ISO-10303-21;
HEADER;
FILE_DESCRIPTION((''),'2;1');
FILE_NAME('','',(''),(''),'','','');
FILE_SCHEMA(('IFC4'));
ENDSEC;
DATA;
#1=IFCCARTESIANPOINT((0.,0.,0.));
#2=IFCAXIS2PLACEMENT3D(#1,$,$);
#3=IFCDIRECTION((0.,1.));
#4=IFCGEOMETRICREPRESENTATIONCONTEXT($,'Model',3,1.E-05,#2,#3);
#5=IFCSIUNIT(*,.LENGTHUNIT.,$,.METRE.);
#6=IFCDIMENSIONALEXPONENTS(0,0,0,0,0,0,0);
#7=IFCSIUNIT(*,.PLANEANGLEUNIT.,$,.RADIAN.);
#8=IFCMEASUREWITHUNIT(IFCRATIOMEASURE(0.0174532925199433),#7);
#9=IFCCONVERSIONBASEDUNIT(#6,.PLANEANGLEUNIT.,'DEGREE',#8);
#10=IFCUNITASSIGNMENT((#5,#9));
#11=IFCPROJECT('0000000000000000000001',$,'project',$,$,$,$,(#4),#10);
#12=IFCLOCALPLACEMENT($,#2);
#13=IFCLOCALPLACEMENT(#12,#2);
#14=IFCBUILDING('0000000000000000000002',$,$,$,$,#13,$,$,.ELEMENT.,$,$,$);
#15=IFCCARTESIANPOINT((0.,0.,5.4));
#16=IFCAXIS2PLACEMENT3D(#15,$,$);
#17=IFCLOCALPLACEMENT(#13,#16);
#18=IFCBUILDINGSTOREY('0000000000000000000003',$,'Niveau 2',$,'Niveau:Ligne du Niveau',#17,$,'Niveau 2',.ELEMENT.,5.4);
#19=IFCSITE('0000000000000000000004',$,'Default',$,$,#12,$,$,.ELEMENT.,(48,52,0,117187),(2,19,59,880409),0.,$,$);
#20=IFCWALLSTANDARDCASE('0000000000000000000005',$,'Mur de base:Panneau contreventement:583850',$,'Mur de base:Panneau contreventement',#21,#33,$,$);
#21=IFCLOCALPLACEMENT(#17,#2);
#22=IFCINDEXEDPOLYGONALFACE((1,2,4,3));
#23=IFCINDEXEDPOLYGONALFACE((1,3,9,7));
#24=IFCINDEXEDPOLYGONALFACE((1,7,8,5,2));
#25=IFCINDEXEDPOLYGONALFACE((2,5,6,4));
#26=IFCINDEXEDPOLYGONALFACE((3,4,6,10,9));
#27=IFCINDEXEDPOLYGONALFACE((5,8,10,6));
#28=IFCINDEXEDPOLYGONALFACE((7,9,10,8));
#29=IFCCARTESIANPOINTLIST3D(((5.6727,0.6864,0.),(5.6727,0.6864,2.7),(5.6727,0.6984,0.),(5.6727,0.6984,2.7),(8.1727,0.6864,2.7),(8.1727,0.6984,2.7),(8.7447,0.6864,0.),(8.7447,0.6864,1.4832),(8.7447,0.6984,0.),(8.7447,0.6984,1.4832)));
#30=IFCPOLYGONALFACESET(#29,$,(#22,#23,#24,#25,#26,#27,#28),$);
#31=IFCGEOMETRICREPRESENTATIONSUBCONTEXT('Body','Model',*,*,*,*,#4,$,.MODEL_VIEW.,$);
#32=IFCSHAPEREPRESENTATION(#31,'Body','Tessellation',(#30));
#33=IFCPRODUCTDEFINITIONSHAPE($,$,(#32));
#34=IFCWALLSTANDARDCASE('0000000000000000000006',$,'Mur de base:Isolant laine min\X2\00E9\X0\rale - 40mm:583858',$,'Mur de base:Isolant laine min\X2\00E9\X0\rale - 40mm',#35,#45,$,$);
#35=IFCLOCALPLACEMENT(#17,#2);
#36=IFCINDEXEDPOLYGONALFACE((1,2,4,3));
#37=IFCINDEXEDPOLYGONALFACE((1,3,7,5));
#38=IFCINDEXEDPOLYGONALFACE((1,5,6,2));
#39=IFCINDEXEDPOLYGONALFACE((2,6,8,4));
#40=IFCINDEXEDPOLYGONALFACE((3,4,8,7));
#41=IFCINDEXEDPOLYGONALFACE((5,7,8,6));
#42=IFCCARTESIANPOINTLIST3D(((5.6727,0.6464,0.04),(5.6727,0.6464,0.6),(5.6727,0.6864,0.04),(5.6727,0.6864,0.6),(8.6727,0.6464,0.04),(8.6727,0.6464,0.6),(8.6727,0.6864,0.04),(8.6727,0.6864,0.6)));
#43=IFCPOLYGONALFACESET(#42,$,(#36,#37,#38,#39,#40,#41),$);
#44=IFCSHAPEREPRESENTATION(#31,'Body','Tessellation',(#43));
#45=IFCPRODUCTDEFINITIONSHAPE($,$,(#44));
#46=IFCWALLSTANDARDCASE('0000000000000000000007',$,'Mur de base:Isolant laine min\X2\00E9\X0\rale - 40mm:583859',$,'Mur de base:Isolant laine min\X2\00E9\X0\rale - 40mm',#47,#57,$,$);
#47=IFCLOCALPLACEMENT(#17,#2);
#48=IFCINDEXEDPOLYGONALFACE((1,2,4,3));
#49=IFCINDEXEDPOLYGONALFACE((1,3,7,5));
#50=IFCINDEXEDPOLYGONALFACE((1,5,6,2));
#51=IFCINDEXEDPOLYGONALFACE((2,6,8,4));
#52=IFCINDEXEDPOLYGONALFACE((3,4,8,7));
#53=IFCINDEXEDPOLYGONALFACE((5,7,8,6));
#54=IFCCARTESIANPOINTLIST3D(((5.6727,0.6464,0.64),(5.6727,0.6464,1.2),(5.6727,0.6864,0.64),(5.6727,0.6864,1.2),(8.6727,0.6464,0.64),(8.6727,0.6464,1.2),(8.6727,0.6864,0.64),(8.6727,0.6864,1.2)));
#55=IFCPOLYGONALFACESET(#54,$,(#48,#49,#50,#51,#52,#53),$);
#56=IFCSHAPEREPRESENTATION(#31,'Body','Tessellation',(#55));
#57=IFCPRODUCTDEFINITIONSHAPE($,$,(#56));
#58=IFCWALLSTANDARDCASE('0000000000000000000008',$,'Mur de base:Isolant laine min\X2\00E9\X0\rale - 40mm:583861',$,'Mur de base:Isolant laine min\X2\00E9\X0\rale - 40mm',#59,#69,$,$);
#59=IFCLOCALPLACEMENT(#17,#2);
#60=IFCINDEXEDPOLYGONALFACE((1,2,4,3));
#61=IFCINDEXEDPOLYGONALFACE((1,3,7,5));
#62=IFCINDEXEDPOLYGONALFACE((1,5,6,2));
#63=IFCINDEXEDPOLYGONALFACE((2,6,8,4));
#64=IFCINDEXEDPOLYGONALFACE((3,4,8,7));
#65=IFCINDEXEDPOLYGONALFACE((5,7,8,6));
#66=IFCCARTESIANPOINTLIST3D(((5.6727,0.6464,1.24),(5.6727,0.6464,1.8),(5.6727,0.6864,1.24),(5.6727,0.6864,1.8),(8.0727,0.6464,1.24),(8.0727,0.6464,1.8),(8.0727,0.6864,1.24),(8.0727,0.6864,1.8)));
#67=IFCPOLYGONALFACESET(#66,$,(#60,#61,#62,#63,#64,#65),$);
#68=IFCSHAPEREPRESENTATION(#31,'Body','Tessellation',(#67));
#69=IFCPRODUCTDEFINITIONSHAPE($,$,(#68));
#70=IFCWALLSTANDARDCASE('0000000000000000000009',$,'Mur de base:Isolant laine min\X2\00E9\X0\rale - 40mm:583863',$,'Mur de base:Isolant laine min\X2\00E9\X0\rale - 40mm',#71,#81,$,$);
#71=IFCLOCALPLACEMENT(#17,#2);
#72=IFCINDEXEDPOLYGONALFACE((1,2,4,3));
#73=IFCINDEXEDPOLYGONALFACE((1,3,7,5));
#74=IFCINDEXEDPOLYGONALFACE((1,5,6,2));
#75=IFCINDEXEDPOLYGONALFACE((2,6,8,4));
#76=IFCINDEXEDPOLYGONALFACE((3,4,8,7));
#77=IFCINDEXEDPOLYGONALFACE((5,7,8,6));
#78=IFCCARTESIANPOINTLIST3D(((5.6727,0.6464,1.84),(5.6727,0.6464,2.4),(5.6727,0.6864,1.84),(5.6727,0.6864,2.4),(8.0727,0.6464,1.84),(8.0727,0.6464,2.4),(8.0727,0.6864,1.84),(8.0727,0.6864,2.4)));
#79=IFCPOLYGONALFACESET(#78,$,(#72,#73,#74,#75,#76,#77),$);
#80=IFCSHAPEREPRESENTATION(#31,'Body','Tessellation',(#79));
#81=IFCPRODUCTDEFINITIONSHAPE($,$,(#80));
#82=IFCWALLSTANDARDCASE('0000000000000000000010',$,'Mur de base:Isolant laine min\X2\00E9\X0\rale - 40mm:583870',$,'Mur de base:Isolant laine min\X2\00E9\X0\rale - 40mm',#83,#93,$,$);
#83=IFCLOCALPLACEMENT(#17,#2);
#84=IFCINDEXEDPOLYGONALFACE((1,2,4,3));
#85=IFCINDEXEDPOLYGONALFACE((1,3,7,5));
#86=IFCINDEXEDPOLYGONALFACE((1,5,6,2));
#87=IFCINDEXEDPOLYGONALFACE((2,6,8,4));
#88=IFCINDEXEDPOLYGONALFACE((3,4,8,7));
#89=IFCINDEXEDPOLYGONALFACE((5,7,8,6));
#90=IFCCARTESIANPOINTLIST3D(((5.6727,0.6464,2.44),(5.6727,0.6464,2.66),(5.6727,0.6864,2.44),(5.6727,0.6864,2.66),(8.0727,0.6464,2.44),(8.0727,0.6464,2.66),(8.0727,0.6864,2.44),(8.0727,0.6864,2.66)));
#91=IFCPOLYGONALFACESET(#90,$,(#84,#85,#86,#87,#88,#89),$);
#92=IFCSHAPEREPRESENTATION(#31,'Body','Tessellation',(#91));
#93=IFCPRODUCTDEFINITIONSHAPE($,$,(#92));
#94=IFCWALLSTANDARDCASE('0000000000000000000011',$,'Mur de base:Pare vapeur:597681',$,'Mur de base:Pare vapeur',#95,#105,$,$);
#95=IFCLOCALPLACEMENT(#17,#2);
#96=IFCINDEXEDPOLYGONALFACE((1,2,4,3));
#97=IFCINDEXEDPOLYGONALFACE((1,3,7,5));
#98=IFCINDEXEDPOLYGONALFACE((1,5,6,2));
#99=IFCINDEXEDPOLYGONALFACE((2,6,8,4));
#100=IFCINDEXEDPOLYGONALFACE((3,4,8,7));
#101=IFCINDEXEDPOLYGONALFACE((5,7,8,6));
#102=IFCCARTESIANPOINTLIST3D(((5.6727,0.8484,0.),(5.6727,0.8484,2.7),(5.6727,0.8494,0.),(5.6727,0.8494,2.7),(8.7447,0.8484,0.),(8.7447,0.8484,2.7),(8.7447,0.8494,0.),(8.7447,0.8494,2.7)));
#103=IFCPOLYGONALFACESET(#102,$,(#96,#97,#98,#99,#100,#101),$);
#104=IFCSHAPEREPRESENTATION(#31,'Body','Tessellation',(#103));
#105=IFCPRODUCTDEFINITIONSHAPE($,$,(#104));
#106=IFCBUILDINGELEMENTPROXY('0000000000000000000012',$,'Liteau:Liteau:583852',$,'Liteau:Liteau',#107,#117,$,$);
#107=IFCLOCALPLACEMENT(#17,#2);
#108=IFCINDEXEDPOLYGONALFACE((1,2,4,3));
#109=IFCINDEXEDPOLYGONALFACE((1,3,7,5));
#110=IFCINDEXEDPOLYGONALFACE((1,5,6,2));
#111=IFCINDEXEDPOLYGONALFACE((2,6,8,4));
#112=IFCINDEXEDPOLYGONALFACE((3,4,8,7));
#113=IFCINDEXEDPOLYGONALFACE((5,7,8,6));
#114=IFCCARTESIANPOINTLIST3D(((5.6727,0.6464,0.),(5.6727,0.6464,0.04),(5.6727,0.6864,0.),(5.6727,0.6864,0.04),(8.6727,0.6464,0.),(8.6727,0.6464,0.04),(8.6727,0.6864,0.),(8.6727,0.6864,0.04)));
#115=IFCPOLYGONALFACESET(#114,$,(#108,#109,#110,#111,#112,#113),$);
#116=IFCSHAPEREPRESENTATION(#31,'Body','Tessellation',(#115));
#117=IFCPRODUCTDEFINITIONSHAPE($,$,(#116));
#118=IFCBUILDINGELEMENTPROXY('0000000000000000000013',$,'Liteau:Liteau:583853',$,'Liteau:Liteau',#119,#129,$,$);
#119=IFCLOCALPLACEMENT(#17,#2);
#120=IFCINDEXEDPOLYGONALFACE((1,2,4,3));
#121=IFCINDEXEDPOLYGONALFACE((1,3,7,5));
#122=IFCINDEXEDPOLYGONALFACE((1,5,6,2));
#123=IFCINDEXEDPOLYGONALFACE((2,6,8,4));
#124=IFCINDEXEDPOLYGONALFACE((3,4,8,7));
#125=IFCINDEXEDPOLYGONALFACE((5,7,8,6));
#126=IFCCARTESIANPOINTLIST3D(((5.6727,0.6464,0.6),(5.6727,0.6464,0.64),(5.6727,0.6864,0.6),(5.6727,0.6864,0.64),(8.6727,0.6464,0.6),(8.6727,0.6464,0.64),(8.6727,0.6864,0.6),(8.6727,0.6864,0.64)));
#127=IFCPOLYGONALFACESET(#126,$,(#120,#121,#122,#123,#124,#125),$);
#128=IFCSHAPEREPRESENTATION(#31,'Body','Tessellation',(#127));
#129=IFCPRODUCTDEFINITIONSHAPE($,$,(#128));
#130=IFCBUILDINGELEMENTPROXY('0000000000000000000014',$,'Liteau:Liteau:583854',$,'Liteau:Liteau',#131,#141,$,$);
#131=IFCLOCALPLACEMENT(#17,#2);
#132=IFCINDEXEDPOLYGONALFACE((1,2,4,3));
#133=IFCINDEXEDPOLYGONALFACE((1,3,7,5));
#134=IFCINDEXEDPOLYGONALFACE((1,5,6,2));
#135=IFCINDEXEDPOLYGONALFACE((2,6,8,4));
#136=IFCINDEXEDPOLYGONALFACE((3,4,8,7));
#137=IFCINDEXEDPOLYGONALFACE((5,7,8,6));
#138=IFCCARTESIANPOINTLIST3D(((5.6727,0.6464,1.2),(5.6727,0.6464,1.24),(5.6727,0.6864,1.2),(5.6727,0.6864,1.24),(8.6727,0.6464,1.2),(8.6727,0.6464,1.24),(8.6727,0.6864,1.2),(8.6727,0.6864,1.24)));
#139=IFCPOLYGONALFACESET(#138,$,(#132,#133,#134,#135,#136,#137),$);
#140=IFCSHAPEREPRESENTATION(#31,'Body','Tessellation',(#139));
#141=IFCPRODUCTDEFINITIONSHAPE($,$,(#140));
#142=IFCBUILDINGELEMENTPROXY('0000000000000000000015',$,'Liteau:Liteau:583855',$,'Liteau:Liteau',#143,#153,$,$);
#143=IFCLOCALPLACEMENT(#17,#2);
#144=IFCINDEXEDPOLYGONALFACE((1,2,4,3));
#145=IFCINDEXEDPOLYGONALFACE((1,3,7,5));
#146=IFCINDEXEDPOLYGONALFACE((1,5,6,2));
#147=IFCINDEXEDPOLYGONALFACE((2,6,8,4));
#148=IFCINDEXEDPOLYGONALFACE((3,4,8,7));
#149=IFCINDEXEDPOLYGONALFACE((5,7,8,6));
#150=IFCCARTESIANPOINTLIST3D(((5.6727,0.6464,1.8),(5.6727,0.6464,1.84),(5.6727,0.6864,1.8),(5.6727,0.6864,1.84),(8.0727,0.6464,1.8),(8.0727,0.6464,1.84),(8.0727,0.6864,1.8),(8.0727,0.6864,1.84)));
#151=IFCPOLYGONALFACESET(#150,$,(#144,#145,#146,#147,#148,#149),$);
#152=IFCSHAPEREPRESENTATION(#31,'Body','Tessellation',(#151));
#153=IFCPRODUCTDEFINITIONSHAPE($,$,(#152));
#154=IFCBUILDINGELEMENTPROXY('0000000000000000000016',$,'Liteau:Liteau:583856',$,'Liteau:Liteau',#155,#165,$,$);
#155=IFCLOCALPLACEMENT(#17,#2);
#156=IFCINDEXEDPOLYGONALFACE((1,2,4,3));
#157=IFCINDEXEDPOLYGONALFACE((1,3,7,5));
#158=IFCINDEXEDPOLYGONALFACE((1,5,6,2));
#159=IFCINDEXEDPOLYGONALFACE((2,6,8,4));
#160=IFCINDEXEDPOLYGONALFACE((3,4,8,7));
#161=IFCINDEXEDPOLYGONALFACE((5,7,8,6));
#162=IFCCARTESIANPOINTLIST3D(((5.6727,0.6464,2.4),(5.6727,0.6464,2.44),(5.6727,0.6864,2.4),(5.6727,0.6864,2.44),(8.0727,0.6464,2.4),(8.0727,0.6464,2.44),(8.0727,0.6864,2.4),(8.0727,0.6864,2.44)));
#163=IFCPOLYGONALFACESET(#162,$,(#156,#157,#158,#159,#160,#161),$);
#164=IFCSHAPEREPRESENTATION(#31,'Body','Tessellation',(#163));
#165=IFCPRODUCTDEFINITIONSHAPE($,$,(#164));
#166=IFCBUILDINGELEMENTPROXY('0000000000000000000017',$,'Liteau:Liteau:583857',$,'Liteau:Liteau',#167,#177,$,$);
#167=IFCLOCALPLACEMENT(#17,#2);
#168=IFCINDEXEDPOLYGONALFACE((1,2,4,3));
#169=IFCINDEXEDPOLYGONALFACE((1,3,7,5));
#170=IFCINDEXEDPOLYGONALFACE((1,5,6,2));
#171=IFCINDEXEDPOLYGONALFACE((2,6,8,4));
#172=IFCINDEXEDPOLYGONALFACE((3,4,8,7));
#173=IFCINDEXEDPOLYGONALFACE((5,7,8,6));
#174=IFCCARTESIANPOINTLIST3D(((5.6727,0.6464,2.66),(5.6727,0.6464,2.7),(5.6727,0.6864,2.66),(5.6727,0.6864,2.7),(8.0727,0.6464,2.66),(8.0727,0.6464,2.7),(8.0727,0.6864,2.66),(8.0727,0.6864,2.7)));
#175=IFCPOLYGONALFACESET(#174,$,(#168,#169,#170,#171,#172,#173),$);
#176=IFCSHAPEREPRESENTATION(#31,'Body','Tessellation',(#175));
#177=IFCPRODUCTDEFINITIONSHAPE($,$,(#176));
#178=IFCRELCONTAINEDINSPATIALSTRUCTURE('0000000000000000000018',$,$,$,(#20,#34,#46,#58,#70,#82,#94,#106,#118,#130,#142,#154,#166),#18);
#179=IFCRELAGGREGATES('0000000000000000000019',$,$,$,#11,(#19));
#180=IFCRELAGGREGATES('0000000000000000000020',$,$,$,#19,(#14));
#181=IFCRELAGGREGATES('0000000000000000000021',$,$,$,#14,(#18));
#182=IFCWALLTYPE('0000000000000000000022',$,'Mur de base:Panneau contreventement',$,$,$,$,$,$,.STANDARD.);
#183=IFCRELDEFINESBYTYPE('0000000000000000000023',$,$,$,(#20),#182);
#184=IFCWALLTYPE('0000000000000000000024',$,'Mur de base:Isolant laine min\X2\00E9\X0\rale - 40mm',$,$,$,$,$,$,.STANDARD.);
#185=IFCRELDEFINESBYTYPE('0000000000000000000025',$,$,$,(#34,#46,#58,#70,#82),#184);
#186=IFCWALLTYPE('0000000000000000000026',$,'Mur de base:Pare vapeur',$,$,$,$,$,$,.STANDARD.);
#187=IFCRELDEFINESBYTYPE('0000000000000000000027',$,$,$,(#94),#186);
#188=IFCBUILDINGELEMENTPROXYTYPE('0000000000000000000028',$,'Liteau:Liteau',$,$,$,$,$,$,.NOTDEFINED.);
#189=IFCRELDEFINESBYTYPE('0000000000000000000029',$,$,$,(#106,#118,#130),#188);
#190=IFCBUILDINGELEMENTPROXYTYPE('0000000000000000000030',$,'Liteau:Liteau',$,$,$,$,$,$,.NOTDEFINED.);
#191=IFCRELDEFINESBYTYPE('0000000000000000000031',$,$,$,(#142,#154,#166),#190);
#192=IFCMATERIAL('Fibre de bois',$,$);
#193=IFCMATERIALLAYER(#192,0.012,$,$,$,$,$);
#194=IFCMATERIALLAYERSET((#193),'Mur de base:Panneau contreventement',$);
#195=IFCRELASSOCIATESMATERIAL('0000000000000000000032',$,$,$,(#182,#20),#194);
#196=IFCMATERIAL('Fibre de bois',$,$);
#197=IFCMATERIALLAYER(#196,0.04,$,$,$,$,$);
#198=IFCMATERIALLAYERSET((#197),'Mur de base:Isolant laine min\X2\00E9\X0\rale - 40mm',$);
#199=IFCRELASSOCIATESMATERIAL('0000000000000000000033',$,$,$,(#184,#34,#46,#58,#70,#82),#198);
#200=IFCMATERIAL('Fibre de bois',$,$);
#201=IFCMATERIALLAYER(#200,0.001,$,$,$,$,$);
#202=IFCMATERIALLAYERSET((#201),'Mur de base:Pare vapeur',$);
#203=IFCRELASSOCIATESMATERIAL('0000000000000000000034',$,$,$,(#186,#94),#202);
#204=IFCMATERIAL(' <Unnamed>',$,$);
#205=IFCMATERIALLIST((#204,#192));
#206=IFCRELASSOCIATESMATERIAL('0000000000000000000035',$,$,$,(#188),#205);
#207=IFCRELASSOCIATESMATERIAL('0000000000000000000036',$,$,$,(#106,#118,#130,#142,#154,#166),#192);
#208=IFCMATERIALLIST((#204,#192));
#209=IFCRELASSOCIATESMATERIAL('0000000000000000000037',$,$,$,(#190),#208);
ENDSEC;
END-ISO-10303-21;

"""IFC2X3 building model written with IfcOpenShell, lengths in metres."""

from ifc_helpers import new_model, entity, si_unit, converted_unit, direction, frame, frame_2d, origin, origin_2d_with_axis, place, context, subcontext, project, spatial, rectangle, extrude, clip, halfspace, source, transform, mapped, material, material_list, layer, layer_set, layer_usage, type_object, type_shapes, element, save


model = new_model("IFC2X3")

# Units and contexts
model_context = context("Model", 3, precision=1e-05, world=origin(), true_north=direction((0.0, 1.0)))
body_context = subcontext(model_context, "Body", "Model", "MODEL_VIEW")
ifc_project = project(units=[si_unit("LENGTHUNIT", "METRE"), converted_unit("PLANEANGLEUNIT", "DEGREE", entity("IfcRatioMeasure", 0.0174532925199433), si_unit("PLANEANGLEUNIT", "RADIAN"), dimensions=[0, 0, 0, 0, 0, 0, 0])], contexts=[model_context])

# Site, building, storey
site_placement = place(None, origin())
site = spatial("IfcSite", under=ifc_project, at=site_placement, Name="Default", CompositionType="ELEMENT", RefLatitude=(48, 52, 0, 117187), RefLongitude=(2, 19, 59, 880409), RefElevation=0.0)
building_placement = place(site_placement, origin())
building = spatial("IfcBuilding", under=site, at=building_placement, CompositionType="ELEMENT")
storey_placement = place(building_placement, frame((0.0, 0.0, 5.4)))
storey = spatial("IfcBuildingStorey", under=building, at=storey_placement, Name="Niveau 2", ObjectType="Niveau:Ligne du Niveau", LongName="Niveau 2", CompositionType="ELEMENT", Elevation=5.4)

# Shared definitions
ifc_material_1 = material(Name="Fibre de bois")

# Walls
ifc_layer_1 = layer(ifc_material_1, 0.012)
ifc_layer_set_1 = layer_set([ifc_layer_1], Name="Mur de base:Panneau contreventement")
ifc_layer_usage_1 = layer_usage(ifc_layer_set_1, "AXIS2", "NEGATIVE", 0.006)
wall_type_1 = type_object("IfcWallType", Name="Mur de base:Panneau contreventement", PredefinedType="STANDARD", material=ifc_layer_set_1)
wall_1_placement = place(storey_placement, frame((5.6727, 0.6924, 0.0)))
element("IfcWallStandardCase", 1, at=wall_1_placement, inside=storey, type_object=wall_type_1, material=ifc_layer_usage_1, Name="Mur de base:Panneau contreventement:583850", ObjectType="Mur de base:Panneau contreventement", context=body_context, shape_type="Clipping", body=[
    clip(extrude(rectangle(XDim=3.072, YDim=0.012, at=frame_2d((1.536, 0.0), x_axis=(-1.0, 0.0))), origin(), (0.0, 0.0, 1.0), 2.7), halfspace(frame((2.5, -0.006, 2.7), z_axis=(0.904996, 0.0, 0.425419), x_axis=(0.0, 1.0, 0.0)), False)),
])
ifc_material_2 = material(Name="Fibre de bois")
ifc_layer_2 = layer(ifc_material_2, 0.04)
ifc_layer_set_2 = layer_set([ifc_layer_2], Name="Mur de base:Isolant laine minérale - 40mm")
ifc_layer_usage_2 = layer_usage(ifc_layer_set_2, "AXIS2", "NEGATIVE", 0.02)
wall_type_2 = type_object("IfcWallType", Name="Mur de base:Isolant laine minérale - 40mm", PredefinedType="STANDARD", material=ifc_layer_set_2)
wall_2_placement = place(storey_placement, frame((5.6727, 0.6664, 0.04)))
element("IfcWallStandardCase", 2, at=wall_2_placement, inside=storey, type_object=wall_type_2, material=ifc_layer_usage_2, Name="Mur de base:Isolant laine minérale - 40mm:583858", ObjectType="Mur de base:Isolant laine minérale - 40mm", context=body_context, shape_type="SweptSolid", body=[
    extrude(rectangle(XDim=3.0, YDim=0.04, at=frame_2d((1.5, 0.0), x_axis=(-1.0, 0.0))), origin(), (0.0, 0.0, 1.0), 0.56),
])
ifc_layer_usage_3 = layer_usage(ifc_layer_set_2, "AXIS2", "NEGATIVE", 0.02)
wall_3_placement = place(storey_placement, frame((5.6727, 0.6664, 0.64)))
element("IfcWallStandardCase", 3, at=wall_3_placement, inside=storey, type_object=wall_type_2, material=ifc_layer_usage_3, Name="Mur de base:Isolant laine minérale - 40mm:583859", ObjectType="Mur de base:Isolant laine minérale - 40mm", context=body_context, shape_type="SweptSolid", body=[
    extrude(rectangle(XDim=3.0, YDim=0.04, at=frame_2d((1.5, 0.0), x_axis=(-1.0, 0.0))), origin(), (0.0, 0.0, 1.0), 0.56),
])
ifc_layer_usage_4 = layer_usage(ifc_layer_set_2, "AXIS2", "NEGATIVE", 0.02)
wall_4_placement = place(storey_placement, frame((5.6727, 0.6664, 1.24)))
element("IfcWallStandardCase", 4, at=wall_4_placement, inside=storey, type_object=wall_type_2, material=ifc_layer_usage_4, Name="Mur de base:Isolant laine minérale - 40mm:583861", ObjectType="Mur de base:Isolant laine minérale - 40mm", context=body_context, shape_type="SweptSolid", body=[
    extrude(rectangle(XDim=2.4, YDim=0.04, at=frame_2d((1.2, 0.0), x_axis=(-1.0, 0.0))), origin(), (0.0, 0.0, 1.0), 0.56),
])
ifc_layer_usage_5 = layer_usage(ifc_layer_set_2, "AXIS2", "NEGATIVE", 0.02)
wall_5_placement = place(storey_placement, frame((5.6727, 0.6664, 1.84)))
element("IfcWallStandardCase", 5, at=wall_5_placement, inside=storey, type_object=wall_type_2, material=ifc_layer_usage_5, Name="Mur de base:Isolant laine minérale - 40mm:583863", ObjectType="Mur de base:Isolant laine minérale - 40mm", context=body_context, shape_type="SweptSolid", body=[
    extrude(rectangle(XDim=2.4, YDim=0.04, at=frame_2d((1.2, 0.0), x_axis=(-1.0, 0.0))), origin(), (0.0, 0.0, 1.0), 0.56),
])
ifc_layer_usage_6 = layer_usage(ifc_layer_set_2, "AXIS2", "NEGATIVE", 0.02)
wall_6_placement = place(storey_placement, frame((5.6727, 0.6664, 2.44)))
element("IfcWallStandardCase", 6, at=wall_6_placement, inside=storey, type_object=wall_type_2, material=ifc_layer_usage_6, Name="Mur de base:Isolant laine minérale - 40mm:583870", ObjectType="Mur de base:Isolant laine minérale - 40mm", context=body_context, shape_type="SweptSolid", body=[
    extrude(rectangle(XDim=2.4, YDim=0.04, at=frame_2d((1.2, 0.0), x_axis=(-1.0, 0.0))), origin(), (0.0, 0.0, 1.0), 0.22),
])
ifc_material_3 = material(Name="Fibre de bois")
ifc_layer_3 = layer(ifc_material_3, 0.001)
ifc_layer_set_3 = layer_set([ifc_layer_3], Name="Mur de base:Pare vapeur")
ifc_layer_usage_7 = layer_usage(ifc_layer_set_3, "AXIS2", "NEGATIVE", 0.0005)
wall_type_3 = type_object("IfcWallType", Name="Mur de base:Pare vapeur", PredefinedType="STANDARD", material=ifc_layer_set_3)
wall_7_placement = place(storey_placement, frame((5.6727, 0.8489, 0.0)))
element("IfcWallStandardCase", 7, at=wall_7_placement, inside=storey, type_object=wall_type_3, material=ifc_layer_usage_7, Name="Mur de base:Pare vapeur:597681", ObjectType="Mur de base:Pare vapeur", context=body_context, shape_type="SweptSolid", body=[
    extrude(rectangle(XDim=3.072, YDim=0.001, at=frame_2d((1.536, 0.0), x_axis=(-1.0, 0.0))), origin(), (0.0, 0.0, 1.0), 2.7),
])

# Building element proxies
ifc_material_4 = material(Name=" <Unnamed>")
ifc_material_list_1 = material_list([ifc_material_4, ifc_material_1])
building_element_proxy_type_1 = type_object("IfcBuildingElementProxyType", Name="Liteau:Liteau", PredefinedType="NOTDEFINED", material=ifc_material_list_1)
shared_shape_1 = source(origin(), body_context, "Body", "SweptSolid", [
    extrude(rectangle(XDim=3.0, YDim=0.04, at=origin_2d_with_axis()), frame((1.5, -0.02, 0.0), z_axis=(0.0, 0.0, 1.0), x_axis=(-1.0, 0.0, 0.0)), (0.0, 0.0, 1.0), 0.04),
])
type_shapes(building_element_proxy_type_1, [shared_shape_1])
for number, where, name in (
    (8, (5.6727, 0.6864, 0.0), "Liteau:Liteau:583852"),
    (9, (5.6727, 0.6864, 0.6), "Liteau:Liteau:583853"),
    (10, (5.6727, 0.6864, 1.2), "Liteau:Liteau:583854"),
):
    element("IfcBuildingElementProxy", number, at=place(storey_placement, frame(where)), inside=storey, type_object=building_element_proxy_type_1, material=ifc_material_1, Name=name, ObjectType="Liteau:Liteau", context=body_context, shape_type="MappedRepresentation", body=[
        mapped(shared_shape_1, transform((0.0, 0.0, 0.0), scale=1.0)),
    ])
ifc_material_list_2 = material_list([ifc_material_4, ifc_material_1])
building_element_proxy_type_2 = type_object("IfcBuildingElementProxyType", Name="Liteau:Liteau", PredefinedType="NOTDEFINED", material=ifc_material_list_2)
shared_shape_2 = source(origin(), body_context, "Body", "SweptSolid", [
    extrude(rectangle(XDim=2.4, YDim=0.04, at=origin_2d_with_axis()), frame((1.2, -0.02, 0.0), z_axis=(0.0, 0.0, 1.0), x_axis=(-1.0, 0.0, 0.0)), (0.0, 0.0, 1.0), 0.04),
])
type_shapes(building_element_proxy_type_2, [shared_shape_2])
for number, where, name in (
    (11, (5.6727, 0.6864, 1.8), "Liteau:Liteau:583855"),
    (12, (5.6727, 0.6864, 2.4), "Liteau:Liteau:583856"),
    (13, (5.6727, 0.6864, 2.66), "Liteau:Liteau:583857"),
):
    element("IfcBuildingElementProxy", number, at=place(storey_placement, frame(where)), inside=storey, type_object=building_element_proxy_type_2, material=ifc_material_1, Name=name, ObjectType="Liteau:Liteau", context=body_context, shape_type="MappedRepresentation", body=[
        mapped(shared_shape_2, transform((0.0, 0.0, 0.0), scale=1.0)),
    ])

save(model, "model.ifc")
